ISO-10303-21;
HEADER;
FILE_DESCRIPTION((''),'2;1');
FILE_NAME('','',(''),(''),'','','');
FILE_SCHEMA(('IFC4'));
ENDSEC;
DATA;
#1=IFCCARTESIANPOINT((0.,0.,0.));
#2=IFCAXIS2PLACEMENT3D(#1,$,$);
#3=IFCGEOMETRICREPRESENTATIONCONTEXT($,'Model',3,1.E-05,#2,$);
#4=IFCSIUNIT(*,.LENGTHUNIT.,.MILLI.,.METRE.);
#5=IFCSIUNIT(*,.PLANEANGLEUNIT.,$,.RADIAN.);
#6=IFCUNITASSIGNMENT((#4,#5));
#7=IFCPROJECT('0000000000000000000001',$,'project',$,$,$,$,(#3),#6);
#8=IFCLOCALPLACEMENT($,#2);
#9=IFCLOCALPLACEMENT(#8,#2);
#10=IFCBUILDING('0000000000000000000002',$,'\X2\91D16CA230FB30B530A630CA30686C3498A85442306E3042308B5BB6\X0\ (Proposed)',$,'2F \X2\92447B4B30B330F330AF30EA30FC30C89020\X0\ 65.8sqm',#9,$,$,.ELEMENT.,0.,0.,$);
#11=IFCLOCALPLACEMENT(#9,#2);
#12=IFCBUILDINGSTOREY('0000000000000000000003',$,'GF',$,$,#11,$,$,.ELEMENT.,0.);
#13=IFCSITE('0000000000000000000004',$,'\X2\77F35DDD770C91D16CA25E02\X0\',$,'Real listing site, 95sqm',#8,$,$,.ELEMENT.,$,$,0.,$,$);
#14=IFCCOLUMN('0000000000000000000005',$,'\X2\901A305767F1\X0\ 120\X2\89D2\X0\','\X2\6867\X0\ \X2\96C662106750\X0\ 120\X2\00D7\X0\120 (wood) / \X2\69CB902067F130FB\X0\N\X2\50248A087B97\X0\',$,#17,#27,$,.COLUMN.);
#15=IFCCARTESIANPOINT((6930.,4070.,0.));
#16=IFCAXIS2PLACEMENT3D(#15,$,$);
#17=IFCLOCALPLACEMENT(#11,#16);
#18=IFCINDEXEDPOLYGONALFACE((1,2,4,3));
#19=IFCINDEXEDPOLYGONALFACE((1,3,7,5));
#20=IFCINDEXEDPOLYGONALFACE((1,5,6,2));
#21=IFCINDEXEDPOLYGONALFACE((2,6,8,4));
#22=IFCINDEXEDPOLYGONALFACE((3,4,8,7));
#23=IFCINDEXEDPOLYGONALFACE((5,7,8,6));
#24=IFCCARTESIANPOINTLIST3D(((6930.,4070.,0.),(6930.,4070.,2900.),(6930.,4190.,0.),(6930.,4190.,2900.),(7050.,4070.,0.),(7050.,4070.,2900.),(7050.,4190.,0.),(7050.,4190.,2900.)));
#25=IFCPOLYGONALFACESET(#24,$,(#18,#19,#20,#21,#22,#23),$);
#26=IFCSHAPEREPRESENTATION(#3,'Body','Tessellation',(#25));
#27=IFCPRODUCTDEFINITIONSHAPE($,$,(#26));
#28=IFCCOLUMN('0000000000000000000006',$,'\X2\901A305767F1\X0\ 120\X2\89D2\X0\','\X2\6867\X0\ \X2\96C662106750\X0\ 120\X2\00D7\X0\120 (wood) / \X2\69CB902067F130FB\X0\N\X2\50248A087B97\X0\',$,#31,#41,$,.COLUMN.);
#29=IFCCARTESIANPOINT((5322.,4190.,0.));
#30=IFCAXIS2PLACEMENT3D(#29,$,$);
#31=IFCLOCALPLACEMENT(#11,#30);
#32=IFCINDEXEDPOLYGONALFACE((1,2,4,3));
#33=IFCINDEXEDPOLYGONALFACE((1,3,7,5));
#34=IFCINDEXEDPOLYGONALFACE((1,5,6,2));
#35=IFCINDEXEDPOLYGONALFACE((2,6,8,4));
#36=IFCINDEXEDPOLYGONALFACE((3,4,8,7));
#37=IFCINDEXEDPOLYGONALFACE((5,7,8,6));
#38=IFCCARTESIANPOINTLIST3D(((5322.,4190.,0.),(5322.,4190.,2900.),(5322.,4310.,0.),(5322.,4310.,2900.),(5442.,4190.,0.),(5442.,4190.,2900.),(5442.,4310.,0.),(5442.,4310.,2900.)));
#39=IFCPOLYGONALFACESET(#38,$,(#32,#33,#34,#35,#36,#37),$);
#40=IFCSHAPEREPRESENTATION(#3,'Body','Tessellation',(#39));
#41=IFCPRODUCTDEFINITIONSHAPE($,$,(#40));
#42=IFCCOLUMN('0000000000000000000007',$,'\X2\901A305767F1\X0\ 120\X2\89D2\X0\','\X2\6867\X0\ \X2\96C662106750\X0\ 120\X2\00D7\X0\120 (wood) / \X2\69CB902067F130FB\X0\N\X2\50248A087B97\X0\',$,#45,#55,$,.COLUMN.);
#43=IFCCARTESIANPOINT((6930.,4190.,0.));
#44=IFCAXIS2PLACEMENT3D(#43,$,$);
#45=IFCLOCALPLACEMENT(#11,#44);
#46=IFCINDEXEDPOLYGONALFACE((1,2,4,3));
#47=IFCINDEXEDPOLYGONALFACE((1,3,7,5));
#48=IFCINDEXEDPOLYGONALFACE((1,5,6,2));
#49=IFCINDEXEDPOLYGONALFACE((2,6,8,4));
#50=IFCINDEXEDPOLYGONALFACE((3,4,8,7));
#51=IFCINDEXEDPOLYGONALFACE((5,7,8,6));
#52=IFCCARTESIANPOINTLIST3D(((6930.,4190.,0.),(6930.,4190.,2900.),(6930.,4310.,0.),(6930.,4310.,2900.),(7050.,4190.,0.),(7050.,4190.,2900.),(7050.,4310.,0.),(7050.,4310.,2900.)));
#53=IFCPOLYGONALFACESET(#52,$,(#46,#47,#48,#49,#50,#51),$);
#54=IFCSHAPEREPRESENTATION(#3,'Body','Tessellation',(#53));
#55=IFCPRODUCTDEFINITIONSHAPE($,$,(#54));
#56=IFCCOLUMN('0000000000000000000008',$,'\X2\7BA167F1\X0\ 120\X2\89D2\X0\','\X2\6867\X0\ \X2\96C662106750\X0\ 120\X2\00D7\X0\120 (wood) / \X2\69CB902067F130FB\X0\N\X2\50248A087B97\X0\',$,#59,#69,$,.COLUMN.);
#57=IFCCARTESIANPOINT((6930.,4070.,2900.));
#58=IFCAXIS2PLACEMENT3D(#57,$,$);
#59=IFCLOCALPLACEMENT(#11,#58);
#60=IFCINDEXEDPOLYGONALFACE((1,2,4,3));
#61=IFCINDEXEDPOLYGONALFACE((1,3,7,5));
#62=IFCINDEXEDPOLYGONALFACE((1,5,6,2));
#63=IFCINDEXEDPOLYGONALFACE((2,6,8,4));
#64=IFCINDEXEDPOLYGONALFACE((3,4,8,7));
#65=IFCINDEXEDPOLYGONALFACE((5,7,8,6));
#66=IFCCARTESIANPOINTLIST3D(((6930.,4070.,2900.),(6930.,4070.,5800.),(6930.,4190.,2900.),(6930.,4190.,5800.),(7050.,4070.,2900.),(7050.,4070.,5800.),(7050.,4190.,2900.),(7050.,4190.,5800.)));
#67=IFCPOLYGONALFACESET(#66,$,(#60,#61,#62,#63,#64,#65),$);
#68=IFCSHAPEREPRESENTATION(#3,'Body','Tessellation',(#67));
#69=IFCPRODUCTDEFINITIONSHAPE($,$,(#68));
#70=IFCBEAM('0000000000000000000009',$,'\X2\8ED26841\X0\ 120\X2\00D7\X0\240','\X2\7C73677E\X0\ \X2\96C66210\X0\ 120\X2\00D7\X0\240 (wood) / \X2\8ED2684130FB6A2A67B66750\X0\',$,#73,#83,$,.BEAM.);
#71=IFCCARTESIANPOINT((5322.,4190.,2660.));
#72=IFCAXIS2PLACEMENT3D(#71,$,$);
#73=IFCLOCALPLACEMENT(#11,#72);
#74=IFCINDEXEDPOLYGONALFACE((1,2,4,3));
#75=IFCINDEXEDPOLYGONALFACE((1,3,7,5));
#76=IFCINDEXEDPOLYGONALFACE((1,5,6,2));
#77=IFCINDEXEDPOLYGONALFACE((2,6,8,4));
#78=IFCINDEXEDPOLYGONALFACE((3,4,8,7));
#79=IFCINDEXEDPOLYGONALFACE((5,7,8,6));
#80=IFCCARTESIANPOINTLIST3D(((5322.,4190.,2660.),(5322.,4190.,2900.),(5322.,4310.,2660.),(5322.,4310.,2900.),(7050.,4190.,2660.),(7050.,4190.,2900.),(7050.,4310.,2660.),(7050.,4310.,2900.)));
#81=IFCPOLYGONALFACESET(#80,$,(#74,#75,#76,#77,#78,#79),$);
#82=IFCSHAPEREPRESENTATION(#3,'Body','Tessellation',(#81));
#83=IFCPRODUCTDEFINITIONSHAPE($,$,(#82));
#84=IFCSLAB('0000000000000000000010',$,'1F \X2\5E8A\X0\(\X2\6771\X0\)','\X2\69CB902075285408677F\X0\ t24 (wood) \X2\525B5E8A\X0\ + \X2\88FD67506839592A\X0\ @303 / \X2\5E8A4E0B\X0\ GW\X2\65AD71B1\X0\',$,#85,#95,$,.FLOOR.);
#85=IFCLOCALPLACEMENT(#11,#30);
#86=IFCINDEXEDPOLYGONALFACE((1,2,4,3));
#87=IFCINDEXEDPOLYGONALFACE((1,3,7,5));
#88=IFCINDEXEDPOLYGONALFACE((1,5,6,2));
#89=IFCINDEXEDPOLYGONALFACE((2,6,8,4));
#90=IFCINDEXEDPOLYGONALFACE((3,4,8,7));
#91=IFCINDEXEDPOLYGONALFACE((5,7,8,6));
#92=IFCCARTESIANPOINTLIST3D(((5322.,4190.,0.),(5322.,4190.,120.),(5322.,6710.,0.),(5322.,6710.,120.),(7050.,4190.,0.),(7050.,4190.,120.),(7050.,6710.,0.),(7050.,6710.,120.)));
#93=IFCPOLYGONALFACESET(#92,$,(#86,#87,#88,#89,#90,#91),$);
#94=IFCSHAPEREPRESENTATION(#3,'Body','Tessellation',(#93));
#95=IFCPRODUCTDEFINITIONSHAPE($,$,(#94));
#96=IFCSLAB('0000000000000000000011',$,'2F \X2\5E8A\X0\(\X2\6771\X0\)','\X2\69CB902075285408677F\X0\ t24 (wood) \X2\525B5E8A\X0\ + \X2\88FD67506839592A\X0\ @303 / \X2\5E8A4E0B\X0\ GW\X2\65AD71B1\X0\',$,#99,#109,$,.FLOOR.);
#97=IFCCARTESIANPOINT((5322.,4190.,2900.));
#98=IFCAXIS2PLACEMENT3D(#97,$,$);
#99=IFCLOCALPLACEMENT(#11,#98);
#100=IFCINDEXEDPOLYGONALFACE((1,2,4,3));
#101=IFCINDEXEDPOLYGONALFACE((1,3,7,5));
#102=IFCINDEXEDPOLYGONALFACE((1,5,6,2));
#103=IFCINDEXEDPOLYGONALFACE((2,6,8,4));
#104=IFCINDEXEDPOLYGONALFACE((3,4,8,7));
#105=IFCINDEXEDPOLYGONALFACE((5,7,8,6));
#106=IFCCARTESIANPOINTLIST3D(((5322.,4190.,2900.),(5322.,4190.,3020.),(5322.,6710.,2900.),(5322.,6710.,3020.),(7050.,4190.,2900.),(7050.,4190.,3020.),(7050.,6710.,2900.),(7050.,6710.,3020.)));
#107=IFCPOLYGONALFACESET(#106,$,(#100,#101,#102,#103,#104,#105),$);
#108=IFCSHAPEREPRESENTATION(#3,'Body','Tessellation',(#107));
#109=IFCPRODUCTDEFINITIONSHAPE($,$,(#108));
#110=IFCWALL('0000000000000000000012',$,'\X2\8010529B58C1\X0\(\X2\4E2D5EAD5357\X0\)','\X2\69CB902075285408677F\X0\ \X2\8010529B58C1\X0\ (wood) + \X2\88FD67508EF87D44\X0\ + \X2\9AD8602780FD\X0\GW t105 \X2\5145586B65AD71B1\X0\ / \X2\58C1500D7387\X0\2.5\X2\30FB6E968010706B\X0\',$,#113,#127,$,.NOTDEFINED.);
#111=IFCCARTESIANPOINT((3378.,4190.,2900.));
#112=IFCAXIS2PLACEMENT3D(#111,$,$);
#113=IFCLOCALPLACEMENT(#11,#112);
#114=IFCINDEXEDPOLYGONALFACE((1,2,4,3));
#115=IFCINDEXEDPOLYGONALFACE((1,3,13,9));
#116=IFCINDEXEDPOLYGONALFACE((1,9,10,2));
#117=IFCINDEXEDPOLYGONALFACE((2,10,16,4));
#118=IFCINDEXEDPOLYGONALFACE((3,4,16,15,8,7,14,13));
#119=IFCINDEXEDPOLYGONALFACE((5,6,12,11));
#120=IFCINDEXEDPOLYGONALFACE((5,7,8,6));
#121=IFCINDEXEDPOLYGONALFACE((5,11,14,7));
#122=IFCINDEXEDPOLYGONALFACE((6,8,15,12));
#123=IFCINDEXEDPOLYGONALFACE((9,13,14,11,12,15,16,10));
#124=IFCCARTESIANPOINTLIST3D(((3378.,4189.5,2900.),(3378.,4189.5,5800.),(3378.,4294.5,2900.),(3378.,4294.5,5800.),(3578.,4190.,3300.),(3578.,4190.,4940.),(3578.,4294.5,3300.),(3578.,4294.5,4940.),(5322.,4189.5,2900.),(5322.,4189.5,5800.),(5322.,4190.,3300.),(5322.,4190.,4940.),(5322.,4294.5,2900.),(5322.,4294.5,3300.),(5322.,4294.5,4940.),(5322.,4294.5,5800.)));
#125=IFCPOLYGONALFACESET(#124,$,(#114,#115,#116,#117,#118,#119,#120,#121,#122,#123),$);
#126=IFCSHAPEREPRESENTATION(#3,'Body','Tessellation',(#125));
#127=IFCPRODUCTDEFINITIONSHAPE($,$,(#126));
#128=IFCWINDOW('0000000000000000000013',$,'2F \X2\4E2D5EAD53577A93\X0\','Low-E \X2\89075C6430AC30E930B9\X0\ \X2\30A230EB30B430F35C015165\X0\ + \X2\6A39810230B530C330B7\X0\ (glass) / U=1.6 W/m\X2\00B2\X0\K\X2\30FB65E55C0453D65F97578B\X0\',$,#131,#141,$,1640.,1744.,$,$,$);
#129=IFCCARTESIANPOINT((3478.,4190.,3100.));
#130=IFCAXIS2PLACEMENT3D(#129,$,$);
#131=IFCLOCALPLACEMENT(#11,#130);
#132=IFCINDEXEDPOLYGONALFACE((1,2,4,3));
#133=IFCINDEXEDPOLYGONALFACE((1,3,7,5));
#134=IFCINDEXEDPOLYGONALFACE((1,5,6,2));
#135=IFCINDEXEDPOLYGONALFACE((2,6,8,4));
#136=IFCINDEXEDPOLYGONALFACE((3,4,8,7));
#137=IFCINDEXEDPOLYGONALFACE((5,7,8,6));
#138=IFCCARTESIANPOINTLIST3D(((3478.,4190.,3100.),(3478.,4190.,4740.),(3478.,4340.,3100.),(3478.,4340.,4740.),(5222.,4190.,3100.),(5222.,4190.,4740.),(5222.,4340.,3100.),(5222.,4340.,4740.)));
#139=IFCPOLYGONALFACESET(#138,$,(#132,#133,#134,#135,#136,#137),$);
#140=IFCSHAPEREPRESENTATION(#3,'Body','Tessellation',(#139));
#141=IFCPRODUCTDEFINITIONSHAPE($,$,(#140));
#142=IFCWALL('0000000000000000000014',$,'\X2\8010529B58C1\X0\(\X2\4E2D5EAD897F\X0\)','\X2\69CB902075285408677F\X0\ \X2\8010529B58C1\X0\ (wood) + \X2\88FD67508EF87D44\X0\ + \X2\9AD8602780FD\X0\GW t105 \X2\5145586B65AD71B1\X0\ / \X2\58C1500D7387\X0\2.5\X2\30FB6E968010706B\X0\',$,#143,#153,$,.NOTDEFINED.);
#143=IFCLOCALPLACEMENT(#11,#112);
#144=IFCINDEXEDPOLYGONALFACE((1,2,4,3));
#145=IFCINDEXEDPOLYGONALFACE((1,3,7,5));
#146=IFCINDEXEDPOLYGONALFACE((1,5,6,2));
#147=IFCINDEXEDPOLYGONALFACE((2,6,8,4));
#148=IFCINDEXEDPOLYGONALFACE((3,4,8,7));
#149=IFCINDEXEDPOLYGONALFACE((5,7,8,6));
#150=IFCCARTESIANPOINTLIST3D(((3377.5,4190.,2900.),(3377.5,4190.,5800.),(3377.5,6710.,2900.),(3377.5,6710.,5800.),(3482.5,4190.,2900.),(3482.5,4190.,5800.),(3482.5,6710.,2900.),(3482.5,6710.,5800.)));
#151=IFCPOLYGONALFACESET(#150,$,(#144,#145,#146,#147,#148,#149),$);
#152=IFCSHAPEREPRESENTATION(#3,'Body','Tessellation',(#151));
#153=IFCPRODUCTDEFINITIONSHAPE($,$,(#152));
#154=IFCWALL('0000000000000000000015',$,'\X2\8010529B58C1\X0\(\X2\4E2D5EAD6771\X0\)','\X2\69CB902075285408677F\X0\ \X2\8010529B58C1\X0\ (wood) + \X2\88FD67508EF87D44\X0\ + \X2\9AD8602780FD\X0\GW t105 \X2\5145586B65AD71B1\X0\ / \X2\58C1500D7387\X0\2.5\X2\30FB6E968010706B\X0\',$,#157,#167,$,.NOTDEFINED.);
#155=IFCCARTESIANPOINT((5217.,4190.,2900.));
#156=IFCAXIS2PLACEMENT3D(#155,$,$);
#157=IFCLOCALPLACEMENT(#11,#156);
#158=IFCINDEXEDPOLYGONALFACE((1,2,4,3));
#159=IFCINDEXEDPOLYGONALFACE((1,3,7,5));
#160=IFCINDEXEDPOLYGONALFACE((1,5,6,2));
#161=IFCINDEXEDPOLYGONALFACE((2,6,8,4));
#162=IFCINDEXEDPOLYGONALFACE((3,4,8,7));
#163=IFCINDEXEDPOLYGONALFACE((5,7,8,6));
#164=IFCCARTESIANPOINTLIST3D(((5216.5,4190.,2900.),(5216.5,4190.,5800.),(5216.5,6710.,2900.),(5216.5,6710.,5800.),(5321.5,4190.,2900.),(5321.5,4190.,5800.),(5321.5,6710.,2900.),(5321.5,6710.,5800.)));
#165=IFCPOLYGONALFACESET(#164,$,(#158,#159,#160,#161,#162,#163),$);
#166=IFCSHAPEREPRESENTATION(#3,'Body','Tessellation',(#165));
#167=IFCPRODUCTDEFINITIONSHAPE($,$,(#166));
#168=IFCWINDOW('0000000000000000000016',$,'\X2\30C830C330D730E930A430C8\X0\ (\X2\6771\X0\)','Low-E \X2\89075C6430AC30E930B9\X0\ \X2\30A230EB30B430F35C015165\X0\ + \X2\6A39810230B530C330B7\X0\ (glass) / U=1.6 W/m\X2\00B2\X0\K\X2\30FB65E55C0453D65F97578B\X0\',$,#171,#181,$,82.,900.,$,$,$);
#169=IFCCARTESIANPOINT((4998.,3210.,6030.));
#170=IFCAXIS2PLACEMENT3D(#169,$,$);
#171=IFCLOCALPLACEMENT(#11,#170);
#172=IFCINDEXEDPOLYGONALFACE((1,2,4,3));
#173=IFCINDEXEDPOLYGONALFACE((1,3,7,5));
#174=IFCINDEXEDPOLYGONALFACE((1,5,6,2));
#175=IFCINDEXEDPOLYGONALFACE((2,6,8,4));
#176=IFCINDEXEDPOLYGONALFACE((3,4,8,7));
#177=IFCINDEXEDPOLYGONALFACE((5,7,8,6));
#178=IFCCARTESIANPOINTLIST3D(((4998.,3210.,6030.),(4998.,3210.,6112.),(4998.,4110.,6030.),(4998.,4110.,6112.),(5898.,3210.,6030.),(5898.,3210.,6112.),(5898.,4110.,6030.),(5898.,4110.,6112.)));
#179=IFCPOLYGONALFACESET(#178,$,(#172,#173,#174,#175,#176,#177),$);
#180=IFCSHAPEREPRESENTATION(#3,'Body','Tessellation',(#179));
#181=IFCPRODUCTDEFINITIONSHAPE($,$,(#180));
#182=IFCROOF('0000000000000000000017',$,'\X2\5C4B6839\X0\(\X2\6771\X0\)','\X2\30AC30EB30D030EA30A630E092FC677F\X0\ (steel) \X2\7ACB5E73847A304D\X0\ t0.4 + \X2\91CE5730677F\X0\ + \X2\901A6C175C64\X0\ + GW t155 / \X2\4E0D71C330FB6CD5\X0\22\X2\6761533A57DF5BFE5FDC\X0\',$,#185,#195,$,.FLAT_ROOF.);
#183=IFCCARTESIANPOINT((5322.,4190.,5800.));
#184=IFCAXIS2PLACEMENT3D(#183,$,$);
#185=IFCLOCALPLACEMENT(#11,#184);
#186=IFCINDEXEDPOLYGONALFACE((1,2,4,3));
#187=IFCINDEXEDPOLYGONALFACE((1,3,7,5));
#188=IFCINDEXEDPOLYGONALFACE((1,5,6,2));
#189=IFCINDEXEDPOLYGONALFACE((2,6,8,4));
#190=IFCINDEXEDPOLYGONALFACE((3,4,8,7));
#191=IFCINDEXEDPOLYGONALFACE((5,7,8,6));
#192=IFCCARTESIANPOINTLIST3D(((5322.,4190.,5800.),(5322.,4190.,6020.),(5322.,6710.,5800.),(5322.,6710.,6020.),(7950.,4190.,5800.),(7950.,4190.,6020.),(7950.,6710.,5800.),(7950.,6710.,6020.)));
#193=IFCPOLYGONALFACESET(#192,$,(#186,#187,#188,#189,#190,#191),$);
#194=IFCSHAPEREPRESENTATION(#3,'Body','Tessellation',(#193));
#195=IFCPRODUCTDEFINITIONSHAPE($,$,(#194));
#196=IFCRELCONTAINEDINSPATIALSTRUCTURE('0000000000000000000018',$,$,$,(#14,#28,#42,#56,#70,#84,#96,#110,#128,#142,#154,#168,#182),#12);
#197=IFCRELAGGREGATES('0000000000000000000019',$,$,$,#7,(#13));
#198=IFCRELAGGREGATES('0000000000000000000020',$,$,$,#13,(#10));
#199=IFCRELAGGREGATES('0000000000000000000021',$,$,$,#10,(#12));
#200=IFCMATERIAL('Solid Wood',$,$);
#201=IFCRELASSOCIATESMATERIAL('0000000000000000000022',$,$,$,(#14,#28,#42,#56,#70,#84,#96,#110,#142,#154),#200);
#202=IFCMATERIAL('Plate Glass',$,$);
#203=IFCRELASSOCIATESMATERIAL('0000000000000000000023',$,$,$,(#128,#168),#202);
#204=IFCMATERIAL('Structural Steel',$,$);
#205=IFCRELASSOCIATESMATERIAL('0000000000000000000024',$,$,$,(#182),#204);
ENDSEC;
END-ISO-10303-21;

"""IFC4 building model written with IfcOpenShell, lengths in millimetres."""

from ifc_helpers import new_model, si_unit, frame, frame_2d, origin, place, context, project, spatial, rectangle, extrude, material, element, fill, save


model = new_model("IFC4")

# Units and contexts
model_context = context("Model", 3, precision=1e-05, world=origin())
ifc_project = project(units=[si_unit("LENGTHUNIT", "METRE", prefix="MILLI"), si_unit("PLANEANGLEUNIT", "RADIAN")], contexts=[model_context])

# Site, building, storey
site_placement = place(None, origin())
site = spatial("IfcSite", under=ifc_project, at=site_placement, Name="石川県金沢市", ObjectType="Real listing site, 95sqm", CompositionType="ELEMENT", RefElevation=0.0)
building_placement = place(site_placement, origin())
building = spatial("IfcBuilding", under=site, at=building_placement, Name="金沢・サウナと水風呂のある家 (Proposed)", ObjectType="2F 鉄筋コンクリート造 65.8sqm", CompositionType="ELEMENT", ElevationOfRefHeight=0.0, ElevationOfTerrain=0.0)
storey_placement = place(building_placement, origin())
storey = spatial("IfcBuildingStorey", under=building, at=storey_placement, Name="GF", CompositionType="ELEMENT", Elevation=0.0)

# Columns
ifc_material_1 = material(Name="Solid Wood")
column_1_placement = place(storey_placement, frame((6930.0, 4070.0, 0.0)))
element("IfcColumn", 1, at=column_1_placement, inside=storey, material=ifc_material_1, Name="通し柱 120角", Description="桧 集成材 120×120 (wood) / 構造柱・N値計算", PredefinedType="COLUMN", context=model_context, shape_type="SweptSolid", body=[
    extrude(rectangle(XDim=120.0, YDim=120.0, at=frame_2d((60.0, 60.0))), frame((6930.0, 4070.0, 0.0)), (0.0, 0.0, 1.0), 2900.0),
])
column_2_placement = place(storey_placement, frame((5322.0, 4190.0, 0.0)))
element("IfcColumn", 2, at=column_2_placement, inside=storey, material=ifc_material_1, Name="通し柱 120角", Description="桧 集成材 120×120 (wood) / 構造柱・N値計算", PredefinedType="COLUMN", context=model_context, shape_type="SweptSolid", body=[
    extrude(rectangle(XDim=120.0, YDim=120.0, at=frame_2d((60.0, 60.0))), frame((5322.0, 4190.0, 0.0)), (0.0, 0.0, 1.0), 2900.0),
])
column_3_placement = place(storey_placement, frame((6930.0, 4190.0, 0.0)))
element("IfcColumn", 3, at=column_3_placement, inside=storey, material=ifc_material_1, Name="通し柱 120角", Description="桧 集成材 120×120 (wood) / 構造柱・N値計算", PredefinedType="COLUMN", context=model_context, shape_type="SweptSolid", body=[
    extrude(rectangle(XDim=120.0, YDim=120.0, at=frame_2d((60.0, 60.0))), frame((6930.0, 4190.0, 0.0)), (0.0, 0.0, 1.0), 2900.0),
])
column_4_placement = place(storey_placement, frame((6930.0, 4070.0, 2900.0)))
element("IfcColumn", 4, at=column_4_placement, inside=storey, material=ifc_material_1, Name="管柱 120角", Description="桧 集成材 120×120 (wood) / 構造柱・N値計算", PredefinedType="COLUMN", context=model_context, shape_type="SweptSolid", body=[
    extrude(rectangle(XDim=120.0, YDim=120.0, at=frame_2d((60.0, 60.0))), frame((6930.0, 4070.0, 2900.0)), (0.0, 0.0, 1.0), 2900.0),
])

# Beam
beam_1_placement = place(storey_placement, frame((5322.0, 4190.0, 2660.0)))
element("IfcBeam", 5, at=beam_1_placement, inside=storey, material=ifc_material_1, Name="軒桁 120×240", Description="米松 集成 120×240 (wood) / 軒桁・横架材", PredefinedType="BEAM", context=model_context, shape_type="SweptSolid", body=[
    extrude(rectangle(XDim=1728.0, YDim=120.0, at=frame_2d((864.0, 60.0))), frame((5322.0, 4190.0, 2660.0)), (0.0, 0.0, 1.0), 240.0),
])

# Slabs
slab_1_placement = place(storey_placement, frame((5322.0, 4190.0, 0.0)))
element("IfcSlab", 6, at=slab_1_placement, inside=storey, material=ifc_material_1, Name="1F 床(東)", Description="構造用合板 t24 (wood) 剛床 + 製材根太 @303 / 床下 GW断熱", PredefinedType="FLOOR", context=model_context, shape_type="SweptSolid", body=[
    extrude(rectangle(XDim=1728.0, YDim=2520.0, at=frame_2d((864.0, 1260.0))), frame((5322.0, 4190.0, 0.0)), (0.0, 0.0, 1.0), 120.0),
])
slab_2_placement = place(storey_placement, frame((5322.0, 4190.0, 2900.0)))
element("IfcSlab", 7, at=slab_2_placement, inside=storey, material=ifc_material_1, Name="2F 床(東)", Description="構造用合板 t24 (wood) 剛床 + 製材根太 @303 / 床下 GW断熱", PredefinedType="FLOOR", context=model_context, shape_type="SweptSolid", body=[
    extrude(rectangle(XDim=1728.0, YDim=2520.0, at=frame_2d((864.0, 1260.0))), frame((5322.0, 4190.0, 2900.0)), (0.0, 0.0, 1.0), 120.0),
])

# Wall, opening, window
wall_1_placement = place(storey_placement, frame((3378.0, 4190.0, 2900.0)))
wall_1 = element("IfcWall", 8, at=wall_1_placement, inside=storey, material=ifc_material_1, Name="耐力壁(中庭南)", Description="構造用合板 耐力壁 (wood) + 製材軸組 + 高性能GW t105 充填断熱 / 壁倍率2.5・準耐火", PredefinedType="NOTDEFINED", context=model_context, shape_type="SweptSolid", body=[
    extrude(rectangle(XDim=1944.0, YDim=105.0, at=frame_2d((972.0, 52.0))), frame((3378.0, 4190.0, 2900.0)), (0.0, 0.0, 1.0), 2900.0),
])
opening_placement = place(storey_placement, frame((3478.0, 4190.0, 3100.0)))
opening = element("IfcOpeningElement", 9, at=opening_placement, cuts=wall_1, PredefinedType="NOTDEFINED", context=model_context, shape_type="SweptSolid", body=[
    extrude(rectangle(XDim=1744.0, YDim=150.0, at=frame_2d((872.0, 75.0))), frame((3478.0, 4190.0, 3100.0)), (0.0, 0.0, 1.0), 1640.0),
])
ifc_material_2 = material(Name="Plate Glass")
window_1_placement = place(storey_placement, frame((3478.0, 4190.0, 3100.0)))
window_1 = element("IfcWindow", 10, at=window_1_placement, inside=storey, material=ifc_material_2, Name="2F 中庭南窓", Description="Low-E 複層ガラス アルゴン封入 + 樹脂サッシ (glass) / U=1.6 W/m²K・日射取得型", OverallHeight=1640.0, OverallWidth=1744.0, context=model_context, shape_type="SweptSolid", body=[
    extrude(rectangle(XDim=1744.0, YDim=150.0, at=frame_2d((872.0, 75.0))), frame((3478.0, 4190.0, 3100.0)), (0.0, 0.0, 1.0), 1640.0),
])
fill(opening, window_1)

# Walls
wall_2_placement = place(storey_placement, frame((3378.0, 4190.0, 2900.0)))
element("IfcWall", 11, at=wall_2_placement, inside=storey, material=ifc_material_1, Name="耐力壁(中庭西)", Description="構造用合板 耐力壁 (wood) + 製材軸組 + 高性能GW t105 充填断熱 / 壁倍率2.5・準耐火", PredefinedType="NOTDEFINED", context=model_context, shape_type="SweptSolid", body=[
    extrude(rectangle(XDim=105.0, YDim=2520.0, at=frame_2d((52.0, 1260.0))), frame((3378.0, 4190.0, 2900.0)), (0.0, 0.0, 1.0), 2900.0),
])
wall_3_placement = place(storey_placement, frame((5217.0, 4190.0, 2900.0)))
element("IfcWall", 12, at=wall_3_placement, inside=storey, material=ifc_material_1, Name="耐力壁(中庭東)", Description="構造用合板 耐力壁 (wood) + 製材軸組 + 高性能GW t105 充填断熱 / 壁倍率2.5・準耐火", PredefinedType="NOTDEFINED", context=model_context, shape_type="SweptSolid", body=[
    extrude(rectangle(XDim=105.0, YDim=2520.0, at=frame_2d((52.0, 1260.0))), frame((5217.0, 4190.0, 2900.0)), (0.0, 0.0, 1.0), 2900.0),
])

# Window
window_2_placement = place(storey_placement, frame((4998.0, 3210.0, 6030.0)))
element("IfcWindow", 13, at=window_2_placement, inside=storey, material=ifc_material_2, Name="トップライト (東)", Description="Low-E 複層ガラス アルゴン封入 + 樹脂サッシ (glass) / U=1.6 W/m²K・日射取得型", OverallHeight=82.0, OverallWidth=900.0, context=model_context, shape_type="SweptSolid", body=[
    extrude(rectangle(XDim=900.0, YDim=900.0, at=frame_2d((450.0, 450.0))), frame((4998.0, 3210.0, 6030.0)), (0.0, 0.0, 1.0), 82.0),
])

# Roof
ifc_material_3 = material(Name="Structural Steel")
for number, where, name in (
    (14, (5322.0, 4190.0, 5800.0), "屋根(東)"),
):
    element("IfcRoof", number, at=place(storey_placement, frame(where)), inside=storey, material=ifc_material_3, Name=name, Description="ガルバリウム鋼板 (steel) 立平葺き t0.4 + 野地板 + 通気層 + GW t155 / 不燃・法22条区域対応", PredefinedType="FLAT_ROOF", context=model_context, shape_type="SweptSolid", body=[
        extrude(rectangle(XDim=2628.0, YDim=2520.0, at=frame_2d((1314.0, 1260.0))), frame((5322.0, 4190.0, 5800.0)), (0.0, 0.0, 1.0), 220.0),
    ])

save(model, "model.ifc")
